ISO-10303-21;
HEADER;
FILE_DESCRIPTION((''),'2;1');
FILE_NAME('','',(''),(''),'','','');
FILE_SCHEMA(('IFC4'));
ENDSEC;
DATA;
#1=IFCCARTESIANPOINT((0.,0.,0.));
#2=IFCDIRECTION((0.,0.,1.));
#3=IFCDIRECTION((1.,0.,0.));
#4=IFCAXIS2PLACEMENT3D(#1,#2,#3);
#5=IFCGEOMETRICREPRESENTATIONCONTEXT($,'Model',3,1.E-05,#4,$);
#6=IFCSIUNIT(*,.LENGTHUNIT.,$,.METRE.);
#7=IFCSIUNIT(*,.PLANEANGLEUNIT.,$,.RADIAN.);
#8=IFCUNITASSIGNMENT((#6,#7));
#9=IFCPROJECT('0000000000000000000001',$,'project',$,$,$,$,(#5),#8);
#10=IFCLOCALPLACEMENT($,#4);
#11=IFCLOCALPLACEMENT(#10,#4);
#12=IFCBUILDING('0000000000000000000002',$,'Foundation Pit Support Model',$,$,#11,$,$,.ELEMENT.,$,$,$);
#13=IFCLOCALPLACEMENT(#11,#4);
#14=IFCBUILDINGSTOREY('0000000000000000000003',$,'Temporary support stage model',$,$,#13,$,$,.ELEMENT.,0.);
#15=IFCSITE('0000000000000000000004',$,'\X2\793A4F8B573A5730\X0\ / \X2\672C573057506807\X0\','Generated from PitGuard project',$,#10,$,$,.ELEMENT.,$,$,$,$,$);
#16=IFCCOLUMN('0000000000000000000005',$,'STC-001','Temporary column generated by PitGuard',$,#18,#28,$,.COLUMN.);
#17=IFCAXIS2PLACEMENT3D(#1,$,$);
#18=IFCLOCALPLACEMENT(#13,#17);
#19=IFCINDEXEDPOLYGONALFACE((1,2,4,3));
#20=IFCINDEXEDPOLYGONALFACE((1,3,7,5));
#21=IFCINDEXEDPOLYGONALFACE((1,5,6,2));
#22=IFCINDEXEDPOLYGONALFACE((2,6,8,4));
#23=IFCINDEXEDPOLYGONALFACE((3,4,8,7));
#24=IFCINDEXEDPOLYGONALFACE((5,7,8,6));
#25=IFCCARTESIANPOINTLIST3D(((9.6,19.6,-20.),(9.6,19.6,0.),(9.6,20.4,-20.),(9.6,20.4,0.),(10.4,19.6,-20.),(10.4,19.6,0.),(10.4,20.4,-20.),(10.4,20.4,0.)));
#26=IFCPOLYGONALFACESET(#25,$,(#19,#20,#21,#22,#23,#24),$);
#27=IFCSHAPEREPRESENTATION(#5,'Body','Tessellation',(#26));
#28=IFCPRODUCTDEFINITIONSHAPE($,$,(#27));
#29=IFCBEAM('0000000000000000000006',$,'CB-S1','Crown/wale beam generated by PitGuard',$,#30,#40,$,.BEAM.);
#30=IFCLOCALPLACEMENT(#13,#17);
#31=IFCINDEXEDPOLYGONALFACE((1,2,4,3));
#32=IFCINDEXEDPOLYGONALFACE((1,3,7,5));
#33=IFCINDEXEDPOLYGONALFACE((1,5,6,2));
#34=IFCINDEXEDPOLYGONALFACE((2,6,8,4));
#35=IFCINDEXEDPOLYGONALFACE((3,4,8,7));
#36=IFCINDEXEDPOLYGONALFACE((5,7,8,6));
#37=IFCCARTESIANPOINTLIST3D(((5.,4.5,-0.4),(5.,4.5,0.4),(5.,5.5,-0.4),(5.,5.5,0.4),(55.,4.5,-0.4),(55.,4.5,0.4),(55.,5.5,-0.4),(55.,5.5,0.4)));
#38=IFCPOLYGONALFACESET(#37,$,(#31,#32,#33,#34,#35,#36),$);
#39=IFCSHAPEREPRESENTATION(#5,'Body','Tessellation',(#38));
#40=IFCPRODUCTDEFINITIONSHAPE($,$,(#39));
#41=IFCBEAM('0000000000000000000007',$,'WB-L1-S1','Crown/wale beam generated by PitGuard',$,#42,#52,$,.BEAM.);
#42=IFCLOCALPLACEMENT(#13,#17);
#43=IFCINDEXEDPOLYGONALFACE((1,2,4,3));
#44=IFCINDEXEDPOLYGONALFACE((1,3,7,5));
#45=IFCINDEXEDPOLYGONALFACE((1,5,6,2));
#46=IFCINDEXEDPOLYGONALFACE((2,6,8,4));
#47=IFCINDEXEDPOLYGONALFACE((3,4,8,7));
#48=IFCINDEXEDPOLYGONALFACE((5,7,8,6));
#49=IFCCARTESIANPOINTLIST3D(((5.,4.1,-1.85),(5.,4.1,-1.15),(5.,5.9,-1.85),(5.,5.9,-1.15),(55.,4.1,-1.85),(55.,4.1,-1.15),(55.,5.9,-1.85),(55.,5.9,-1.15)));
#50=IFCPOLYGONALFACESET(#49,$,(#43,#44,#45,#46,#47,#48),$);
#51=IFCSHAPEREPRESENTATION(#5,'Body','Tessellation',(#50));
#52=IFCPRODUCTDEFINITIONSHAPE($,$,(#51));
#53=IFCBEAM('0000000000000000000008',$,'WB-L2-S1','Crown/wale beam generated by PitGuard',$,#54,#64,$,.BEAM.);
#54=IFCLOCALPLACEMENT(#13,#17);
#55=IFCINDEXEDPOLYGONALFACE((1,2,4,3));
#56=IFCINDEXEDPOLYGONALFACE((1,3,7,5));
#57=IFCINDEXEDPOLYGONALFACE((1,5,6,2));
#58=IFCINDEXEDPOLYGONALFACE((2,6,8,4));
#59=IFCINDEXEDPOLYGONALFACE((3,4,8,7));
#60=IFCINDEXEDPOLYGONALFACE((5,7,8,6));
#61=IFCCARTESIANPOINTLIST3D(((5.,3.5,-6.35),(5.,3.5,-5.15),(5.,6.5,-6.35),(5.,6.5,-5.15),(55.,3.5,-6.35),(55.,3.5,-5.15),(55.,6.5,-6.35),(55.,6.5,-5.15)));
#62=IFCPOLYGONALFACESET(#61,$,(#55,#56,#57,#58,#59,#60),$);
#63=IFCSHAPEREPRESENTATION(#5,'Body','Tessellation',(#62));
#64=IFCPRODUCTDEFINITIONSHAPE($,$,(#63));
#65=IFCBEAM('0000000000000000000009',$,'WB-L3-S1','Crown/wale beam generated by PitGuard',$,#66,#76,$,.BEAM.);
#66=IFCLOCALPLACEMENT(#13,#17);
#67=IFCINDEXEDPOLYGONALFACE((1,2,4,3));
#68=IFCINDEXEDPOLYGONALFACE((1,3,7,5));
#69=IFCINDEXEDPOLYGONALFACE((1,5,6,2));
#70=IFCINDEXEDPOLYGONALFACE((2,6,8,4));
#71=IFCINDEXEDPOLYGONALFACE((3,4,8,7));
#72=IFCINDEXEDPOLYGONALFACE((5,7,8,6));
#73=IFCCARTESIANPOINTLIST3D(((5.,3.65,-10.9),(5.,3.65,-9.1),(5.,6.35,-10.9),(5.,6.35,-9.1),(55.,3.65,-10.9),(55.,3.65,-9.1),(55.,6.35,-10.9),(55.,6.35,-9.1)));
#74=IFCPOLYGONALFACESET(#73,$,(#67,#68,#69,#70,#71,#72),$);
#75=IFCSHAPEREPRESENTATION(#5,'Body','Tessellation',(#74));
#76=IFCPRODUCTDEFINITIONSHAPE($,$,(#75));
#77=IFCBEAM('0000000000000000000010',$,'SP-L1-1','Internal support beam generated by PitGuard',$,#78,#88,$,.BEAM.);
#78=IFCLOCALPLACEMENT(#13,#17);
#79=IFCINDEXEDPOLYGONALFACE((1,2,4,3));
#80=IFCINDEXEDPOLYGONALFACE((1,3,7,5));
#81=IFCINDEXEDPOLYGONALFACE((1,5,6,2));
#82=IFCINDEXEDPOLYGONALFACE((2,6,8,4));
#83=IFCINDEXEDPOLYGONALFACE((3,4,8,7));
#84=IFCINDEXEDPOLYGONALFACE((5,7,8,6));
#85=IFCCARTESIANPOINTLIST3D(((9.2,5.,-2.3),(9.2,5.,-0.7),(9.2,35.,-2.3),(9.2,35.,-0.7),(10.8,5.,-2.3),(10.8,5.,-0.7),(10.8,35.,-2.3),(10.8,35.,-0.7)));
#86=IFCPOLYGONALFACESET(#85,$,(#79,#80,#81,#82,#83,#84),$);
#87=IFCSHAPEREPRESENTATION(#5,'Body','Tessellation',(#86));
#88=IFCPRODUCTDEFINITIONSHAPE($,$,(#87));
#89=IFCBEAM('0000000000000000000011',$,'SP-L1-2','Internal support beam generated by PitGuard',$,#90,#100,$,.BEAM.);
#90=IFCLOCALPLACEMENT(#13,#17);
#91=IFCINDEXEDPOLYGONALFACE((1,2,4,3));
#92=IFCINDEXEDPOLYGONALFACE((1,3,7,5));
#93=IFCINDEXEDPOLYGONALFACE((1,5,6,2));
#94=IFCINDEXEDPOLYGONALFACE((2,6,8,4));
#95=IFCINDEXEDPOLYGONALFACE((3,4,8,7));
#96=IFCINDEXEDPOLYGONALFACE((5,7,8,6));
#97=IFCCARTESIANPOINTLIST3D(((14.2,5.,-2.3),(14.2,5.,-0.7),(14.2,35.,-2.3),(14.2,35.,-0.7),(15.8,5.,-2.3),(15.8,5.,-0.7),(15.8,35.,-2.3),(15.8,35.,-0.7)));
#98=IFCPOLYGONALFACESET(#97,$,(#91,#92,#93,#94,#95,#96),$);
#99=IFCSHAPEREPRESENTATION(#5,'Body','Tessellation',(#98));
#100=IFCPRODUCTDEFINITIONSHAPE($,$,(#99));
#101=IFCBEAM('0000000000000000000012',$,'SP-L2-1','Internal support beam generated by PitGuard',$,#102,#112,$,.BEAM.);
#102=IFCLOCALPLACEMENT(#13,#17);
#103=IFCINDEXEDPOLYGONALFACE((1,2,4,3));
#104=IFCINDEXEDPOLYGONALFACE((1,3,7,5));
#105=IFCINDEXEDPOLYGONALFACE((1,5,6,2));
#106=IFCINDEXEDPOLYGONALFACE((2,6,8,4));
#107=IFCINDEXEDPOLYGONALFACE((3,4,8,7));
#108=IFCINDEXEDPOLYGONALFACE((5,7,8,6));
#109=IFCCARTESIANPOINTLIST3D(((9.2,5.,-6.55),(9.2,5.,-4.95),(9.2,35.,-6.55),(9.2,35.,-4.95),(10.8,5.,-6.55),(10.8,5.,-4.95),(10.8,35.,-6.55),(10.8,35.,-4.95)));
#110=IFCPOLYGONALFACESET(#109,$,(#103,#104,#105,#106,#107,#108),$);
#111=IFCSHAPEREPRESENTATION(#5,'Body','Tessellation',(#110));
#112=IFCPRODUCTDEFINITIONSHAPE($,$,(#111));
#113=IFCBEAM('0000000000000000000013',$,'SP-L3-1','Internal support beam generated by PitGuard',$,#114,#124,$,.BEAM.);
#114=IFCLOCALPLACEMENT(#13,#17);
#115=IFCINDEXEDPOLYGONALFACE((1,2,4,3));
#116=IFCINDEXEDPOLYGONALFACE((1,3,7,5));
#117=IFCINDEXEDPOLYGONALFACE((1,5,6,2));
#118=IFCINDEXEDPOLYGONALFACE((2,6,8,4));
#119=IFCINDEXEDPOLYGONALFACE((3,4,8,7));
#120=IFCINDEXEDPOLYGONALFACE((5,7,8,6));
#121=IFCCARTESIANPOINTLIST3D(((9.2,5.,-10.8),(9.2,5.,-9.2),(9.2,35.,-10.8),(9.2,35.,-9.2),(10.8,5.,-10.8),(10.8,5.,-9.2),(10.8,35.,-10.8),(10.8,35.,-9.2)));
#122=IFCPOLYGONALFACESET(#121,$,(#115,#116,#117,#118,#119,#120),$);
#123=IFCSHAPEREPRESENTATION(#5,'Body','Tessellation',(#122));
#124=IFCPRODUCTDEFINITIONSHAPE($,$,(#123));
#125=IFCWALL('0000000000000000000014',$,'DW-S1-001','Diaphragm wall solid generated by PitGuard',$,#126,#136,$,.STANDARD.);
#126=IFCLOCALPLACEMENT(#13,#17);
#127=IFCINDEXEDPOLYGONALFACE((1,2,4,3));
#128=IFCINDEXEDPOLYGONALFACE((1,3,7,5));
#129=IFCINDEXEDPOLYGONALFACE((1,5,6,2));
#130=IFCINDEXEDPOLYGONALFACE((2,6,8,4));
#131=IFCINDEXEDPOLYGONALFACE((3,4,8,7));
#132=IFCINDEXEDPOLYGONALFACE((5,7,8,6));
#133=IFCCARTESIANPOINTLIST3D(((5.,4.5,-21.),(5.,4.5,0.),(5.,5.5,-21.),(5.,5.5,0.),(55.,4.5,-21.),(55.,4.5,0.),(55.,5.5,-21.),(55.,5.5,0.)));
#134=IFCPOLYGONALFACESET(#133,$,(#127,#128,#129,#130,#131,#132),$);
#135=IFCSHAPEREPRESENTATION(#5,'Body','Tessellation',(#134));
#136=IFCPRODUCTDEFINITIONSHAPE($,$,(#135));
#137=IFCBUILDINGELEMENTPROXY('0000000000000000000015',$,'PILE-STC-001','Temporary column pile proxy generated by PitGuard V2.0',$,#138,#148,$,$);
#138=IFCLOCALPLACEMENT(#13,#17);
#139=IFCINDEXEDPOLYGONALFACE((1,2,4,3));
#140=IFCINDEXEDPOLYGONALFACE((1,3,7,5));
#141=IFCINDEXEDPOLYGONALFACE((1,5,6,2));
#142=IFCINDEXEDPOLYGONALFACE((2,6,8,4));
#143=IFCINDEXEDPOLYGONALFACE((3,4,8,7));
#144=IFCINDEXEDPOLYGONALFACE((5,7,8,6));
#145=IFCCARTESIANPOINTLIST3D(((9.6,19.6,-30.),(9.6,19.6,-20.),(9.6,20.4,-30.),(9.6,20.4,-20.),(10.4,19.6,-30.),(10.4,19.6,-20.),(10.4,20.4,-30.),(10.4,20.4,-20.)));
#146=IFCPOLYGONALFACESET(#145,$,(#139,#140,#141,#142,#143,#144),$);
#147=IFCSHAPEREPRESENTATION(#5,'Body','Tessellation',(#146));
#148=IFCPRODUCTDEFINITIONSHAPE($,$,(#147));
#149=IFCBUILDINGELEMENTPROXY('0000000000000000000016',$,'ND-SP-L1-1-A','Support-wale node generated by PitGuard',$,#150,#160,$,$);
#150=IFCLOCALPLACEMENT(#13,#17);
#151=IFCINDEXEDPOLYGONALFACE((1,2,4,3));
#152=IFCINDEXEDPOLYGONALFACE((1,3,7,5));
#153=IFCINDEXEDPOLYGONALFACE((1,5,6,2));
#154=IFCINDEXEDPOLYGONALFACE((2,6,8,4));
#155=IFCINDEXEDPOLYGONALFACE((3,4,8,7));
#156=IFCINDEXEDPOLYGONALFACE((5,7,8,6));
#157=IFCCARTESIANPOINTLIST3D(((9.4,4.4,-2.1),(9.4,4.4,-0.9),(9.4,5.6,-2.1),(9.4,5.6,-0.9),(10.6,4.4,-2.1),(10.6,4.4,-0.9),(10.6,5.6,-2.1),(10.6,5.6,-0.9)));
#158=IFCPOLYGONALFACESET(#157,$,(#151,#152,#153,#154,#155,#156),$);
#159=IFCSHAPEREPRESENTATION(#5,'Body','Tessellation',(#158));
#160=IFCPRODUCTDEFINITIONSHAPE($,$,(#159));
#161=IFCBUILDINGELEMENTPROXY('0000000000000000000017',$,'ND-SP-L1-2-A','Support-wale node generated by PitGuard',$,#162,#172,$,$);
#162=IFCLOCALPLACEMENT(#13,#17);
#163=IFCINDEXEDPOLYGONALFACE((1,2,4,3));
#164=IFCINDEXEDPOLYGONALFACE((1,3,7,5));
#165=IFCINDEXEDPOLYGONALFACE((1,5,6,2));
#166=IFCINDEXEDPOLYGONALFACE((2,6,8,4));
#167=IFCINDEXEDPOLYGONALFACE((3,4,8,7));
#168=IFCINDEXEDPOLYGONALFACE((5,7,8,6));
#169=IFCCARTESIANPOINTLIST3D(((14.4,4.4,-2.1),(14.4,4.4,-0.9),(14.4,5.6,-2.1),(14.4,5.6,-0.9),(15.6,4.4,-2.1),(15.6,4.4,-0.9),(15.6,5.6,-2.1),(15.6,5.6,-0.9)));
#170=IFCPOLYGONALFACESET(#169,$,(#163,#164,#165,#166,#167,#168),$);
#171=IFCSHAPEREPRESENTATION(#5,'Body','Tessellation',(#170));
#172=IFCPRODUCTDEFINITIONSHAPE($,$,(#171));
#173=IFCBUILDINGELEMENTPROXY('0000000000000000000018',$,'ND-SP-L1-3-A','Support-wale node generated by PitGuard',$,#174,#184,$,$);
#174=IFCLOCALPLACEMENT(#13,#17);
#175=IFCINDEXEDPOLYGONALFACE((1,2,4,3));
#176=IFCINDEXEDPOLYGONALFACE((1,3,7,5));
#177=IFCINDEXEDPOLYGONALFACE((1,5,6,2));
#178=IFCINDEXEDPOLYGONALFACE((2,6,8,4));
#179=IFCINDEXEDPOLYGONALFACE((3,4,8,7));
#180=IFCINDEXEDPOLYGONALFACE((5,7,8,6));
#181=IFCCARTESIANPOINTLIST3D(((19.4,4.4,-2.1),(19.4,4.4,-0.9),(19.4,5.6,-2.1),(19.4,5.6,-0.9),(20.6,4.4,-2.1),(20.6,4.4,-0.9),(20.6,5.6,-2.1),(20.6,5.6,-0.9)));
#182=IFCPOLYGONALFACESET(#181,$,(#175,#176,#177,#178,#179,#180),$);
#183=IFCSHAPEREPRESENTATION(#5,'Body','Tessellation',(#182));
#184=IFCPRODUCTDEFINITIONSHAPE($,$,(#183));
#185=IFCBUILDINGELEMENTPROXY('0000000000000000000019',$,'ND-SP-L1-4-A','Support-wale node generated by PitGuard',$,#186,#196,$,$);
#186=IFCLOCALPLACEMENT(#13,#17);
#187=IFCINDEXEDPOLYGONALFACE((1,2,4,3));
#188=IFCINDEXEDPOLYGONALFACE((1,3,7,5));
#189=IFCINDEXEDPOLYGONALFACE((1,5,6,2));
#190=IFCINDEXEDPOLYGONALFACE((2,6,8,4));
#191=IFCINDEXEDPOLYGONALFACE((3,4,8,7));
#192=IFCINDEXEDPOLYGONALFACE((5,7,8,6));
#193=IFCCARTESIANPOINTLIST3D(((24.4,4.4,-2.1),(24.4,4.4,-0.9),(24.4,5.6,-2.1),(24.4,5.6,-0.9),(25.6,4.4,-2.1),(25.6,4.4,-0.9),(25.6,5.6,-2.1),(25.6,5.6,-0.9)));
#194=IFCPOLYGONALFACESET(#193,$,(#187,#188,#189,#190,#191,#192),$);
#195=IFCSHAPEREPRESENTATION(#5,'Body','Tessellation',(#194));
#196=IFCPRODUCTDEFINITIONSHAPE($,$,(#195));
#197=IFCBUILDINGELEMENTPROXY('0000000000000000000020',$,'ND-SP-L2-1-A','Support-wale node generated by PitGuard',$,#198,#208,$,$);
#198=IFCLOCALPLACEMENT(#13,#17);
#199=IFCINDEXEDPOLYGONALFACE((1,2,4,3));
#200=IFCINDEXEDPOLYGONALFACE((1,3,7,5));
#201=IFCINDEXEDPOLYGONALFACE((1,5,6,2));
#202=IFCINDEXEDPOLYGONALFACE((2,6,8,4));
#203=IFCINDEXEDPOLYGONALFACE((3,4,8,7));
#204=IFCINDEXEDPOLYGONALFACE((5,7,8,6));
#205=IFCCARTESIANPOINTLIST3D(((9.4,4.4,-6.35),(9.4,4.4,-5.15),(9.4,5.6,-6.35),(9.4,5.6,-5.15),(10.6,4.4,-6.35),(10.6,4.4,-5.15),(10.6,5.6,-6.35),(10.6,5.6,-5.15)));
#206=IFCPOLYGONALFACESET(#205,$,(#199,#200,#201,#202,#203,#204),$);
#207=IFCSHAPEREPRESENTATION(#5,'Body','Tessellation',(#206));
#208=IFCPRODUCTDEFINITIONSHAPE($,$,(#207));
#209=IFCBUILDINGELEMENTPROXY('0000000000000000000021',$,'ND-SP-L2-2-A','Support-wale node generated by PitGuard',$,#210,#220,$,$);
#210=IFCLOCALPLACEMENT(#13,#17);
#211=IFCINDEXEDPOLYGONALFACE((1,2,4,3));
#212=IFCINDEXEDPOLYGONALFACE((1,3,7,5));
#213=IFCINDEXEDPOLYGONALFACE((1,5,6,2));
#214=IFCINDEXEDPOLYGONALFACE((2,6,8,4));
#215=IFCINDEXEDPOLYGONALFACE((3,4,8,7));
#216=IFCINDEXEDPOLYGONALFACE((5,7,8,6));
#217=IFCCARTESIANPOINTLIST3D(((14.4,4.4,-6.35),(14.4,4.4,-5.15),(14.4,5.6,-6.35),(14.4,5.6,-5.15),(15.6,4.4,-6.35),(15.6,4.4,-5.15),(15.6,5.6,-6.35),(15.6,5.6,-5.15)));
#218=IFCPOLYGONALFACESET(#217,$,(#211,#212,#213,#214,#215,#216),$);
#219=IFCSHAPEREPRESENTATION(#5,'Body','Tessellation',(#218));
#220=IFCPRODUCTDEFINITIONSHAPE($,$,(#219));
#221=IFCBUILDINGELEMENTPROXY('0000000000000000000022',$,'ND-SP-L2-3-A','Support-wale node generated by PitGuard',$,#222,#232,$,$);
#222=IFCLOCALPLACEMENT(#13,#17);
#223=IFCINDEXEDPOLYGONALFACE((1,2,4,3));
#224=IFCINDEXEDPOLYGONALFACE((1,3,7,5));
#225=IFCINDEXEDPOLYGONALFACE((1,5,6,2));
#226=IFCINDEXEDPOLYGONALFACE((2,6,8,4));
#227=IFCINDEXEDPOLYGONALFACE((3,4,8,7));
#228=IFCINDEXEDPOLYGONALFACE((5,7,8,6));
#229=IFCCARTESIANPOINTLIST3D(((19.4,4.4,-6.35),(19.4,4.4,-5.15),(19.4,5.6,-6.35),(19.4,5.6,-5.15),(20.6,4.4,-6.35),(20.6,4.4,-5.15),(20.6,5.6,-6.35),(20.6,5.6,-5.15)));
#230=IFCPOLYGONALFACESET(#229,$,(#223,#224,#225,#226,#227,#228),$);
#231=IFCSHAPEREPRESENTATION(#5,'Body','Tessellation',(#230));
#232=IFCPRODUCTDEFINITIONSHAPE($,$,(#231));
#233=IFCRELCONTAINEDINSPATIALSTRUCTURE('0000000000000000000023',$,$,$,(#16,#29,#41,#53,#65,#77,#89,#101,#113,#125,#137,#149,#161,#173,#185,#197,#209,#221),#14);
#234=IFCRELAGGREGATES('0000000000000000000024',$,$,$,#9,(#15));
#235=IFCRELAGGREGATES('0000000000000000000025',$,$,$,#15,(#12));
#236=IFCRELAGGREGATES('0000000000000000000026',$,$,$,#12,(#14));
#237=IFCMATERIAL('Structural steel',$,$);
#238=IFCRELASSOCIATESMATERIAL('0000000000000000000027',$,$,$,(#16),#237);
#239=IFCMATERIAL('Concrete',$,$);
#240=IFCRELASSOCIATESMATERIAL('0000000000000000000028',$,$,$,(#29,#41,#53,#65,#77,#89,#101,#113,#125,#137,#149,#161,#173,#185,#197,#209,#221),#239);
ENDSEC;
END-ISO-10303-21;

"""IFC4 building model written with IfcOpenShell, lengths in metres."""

from ifc_helpers import new_model, si_unit, frame, origin_with_axes, origin_2d, place, context, project, spatial, rectangle, extrude, material, element, save


model = new_model("IFC4")

# Units and contexts
model_context = context("Model", 3, precision=1e-05, world=origin_with_axes())
ifc_project = project(units=[si_unit("LENGTHUNIT", "METRE"), si_unit("PLANEANGLEUNIT", "RADIAN")], contexts=[model_context])

# Site, building, storey
site_placement = place(None, origin_with_axes())
site = spatial("IfcSite", under=ifc_project, at=site_placement, Name="示例场地 / 本地坐标", Description="Generated from PitGuard project", CompositionType="ELEMENT")
building_placement = place(site_placement, origin_with_axes())
building = spatial("IfcBuilding", under=site, at=building_placement, Name="Foundation Pit Support Model", CompositionType="ELEMENT")
storey_placement = place(building_placement, origin_with_axes())
storey = spatial("IfcBuildingStorey", under=building, at=storey_placement, Name="Temporary support stage model", CompositionType="ELEMENT", Elevation=0.0)

# Column
ifc_material_1 = material(Name="Structural steel")
column_placement = place(storey_placement, frame((10.0, 20.0, -20.0), z_axis=(0.0, 0.0, 1.0), x_axis=(1.0, 0.0, 0.0)))
element("IfcColumn", 1, at=column_placement, inside=storey, material=ifc_material_1, Name="STC-001", Description="Temporary column generated by PitGuard", PredefinedType="COLUMN", context=model_context, shape_type="SweptSolid", body=[
    extrude(rectangle(XDim=0.8, YDim=0.8, at=origin_2d()), origin_with_axes(), (0.0, 0.0, 1.0), 20.0),
])

# Beams
ifc_material_2 = material(Name="Concrete")
beam_1_placement = place(storey_placement, frame((30.0, 5.0, -0.4), z_axis=(0.0, 0.0, 1.0), x_axis=(1.0, 0.0, 0.0)))
element("IfcBeam", 2, at=beam_1_placement, inside=storey, material=ifc_material_2, Name="CB-S1", Description="Crown/wale beam generated by PitGuard", PredefinedType="BEAM", context=model_context, shape_type="SweptSolid", body=[
    extrude(rectangle(XDim=50.0, YDim=1.0, at=origin_2d()), origin_with_axes(), (0.0, 0.0, 1.0), 0.8),
])
beam_2_placement = place(storey_placement, frame((30.0, 5.0, -1.85), z_axis=(0.0, 0.0, 1.0), x_axis=(1.0, 0.0, 0.0)))
element("IfcBeam", 3, at=beam_2_placement, inside=storey, material=ifc_material_2, Name="WB-L1-S1", Description="Crown/wale beam generated by PitGuard", PredefinedType="BEAM", context=model_context, shape_type="SweptSolid", body=[
    extrude(rectangle(XDim=50.0, YDim=1.8, at=origin_2d()), origin_with_axes(), (0.0, 0.0, 1.0), 0.7),
])
beam_3_placement = place(storey_placement, frame((30.0, 5.0, -6.35), z_axis=(0.0, 0.0, 1.0), x_axis=(1.0, 0.0, 0.0)))
element("IfcBeam", 4, at=beam_3_placement, inside=storey, material=ifc_material_2, Name="WB-L2-S1", Description="Crown/wale beam generated by PitGuard", PredefinedType="BEAM", context=model_context, shape_type="SweptSolid", body=[
    extrude(rectangle(XDim=50.0, YDim=3.0, at=origin_2d()), origin_with_axes(), (0.0, 0.0, 1.0), 1.2),
])
beam_4_placement = place(storey_placement, frame((30.0, 5.0, -10.9), z_axis=(0.0, 0.0, 1.0), x_axis=(1.0, 0.0, 0.0)))
element("IfcBeam", 5, at=beam_4_placement, inside=storey, material=ifc_material_2, Name="WB-L3-S1", Description="Crown/wale beam generated by PitGuard", PredefinedType="BEAM", context=model_context, shape_type="SweptSolid", body=[
    extrude(rectangle(XDim=50.0, YDim=2.7, at=origin_2d()), origin_with_axes(), (0.0, 0.0, 1.0), 1.8),
])
for number, where, z_axis, x_axis, name in (
    (6, (10.0, 20.0, -2.3), (0.0, 0.0, 1.0), (0.0, 1.0, 0.0), "SP-L1-1"),
    (7, (15.0, 20.0, -2.3), (0.0, 0.0, 1.0), (0.0, 1.0, 0.0), "SP-L1-2"),
    (8, (10.0, 20.0, -6.55), (0.0, 0.0, 1.0), (0.0, 1.0, 0.0), "SP-L2-1"),
    (9, (10.0, 20.0, -10.8), (0.0, 0.0, 1.0), (0.0, 1.0, 0.0), "SP-L3-1"),
):
    element("IfcBeam", number, at=place(storey_placement, frame(where, z_axis=z_axis, x_axis=x_axis)), inside=storey, material=ifc_material_2, Name=name, Description="Internal support beam generated by PitGuard", PredefinedType="BEAM", context=model_context, shape_type="SweptSolid", body=[
        extrude(rectangle(XDim=30.0, YDim=1.6, at=origin_2d()), origin_with_axes(), (0.0, 0.0, 1.0), 1.6),
    ])

# Wall
wall_placement = place(storey_placement, frame((30.0, 5.0, -21.0), z_axis=(0.0, 0.0, 1.0), x_axis=(1.0, 0.0, 0.0)))
element("IfcWall", 10, at=wall_placement, inside=storey, material=ifc_material_2, Name="DW-S1-001", Description="Diaphragm wall solid generated by PitGuard", PredefinedType="STANDARD", context=model_context, shape_type="SweptSolid", body=[
    extrude(rectangle(XDim=50.0, YDim=1.0, at=origin_2d()), origin_with_axes(), (0.0, 0.0, 1.0), 21.0),
])

# Building element proxies
proxy_placement = place(storey_placement, frame((10.0, 20.0, -30.0), z_axis=(0.0, 0.0, 1.0), x_axis=(1.0, 0.0, 0.0)))
element("IfcBuildingElementProxy", 11, at=proxy_placement, inside=storey, material=ifc_material_2, Name="PILE-STC-001", Description="Temporary column pile proxy generated by PitGuard V2.0", context=model_context, shape_type="SweptSolid", body=[
    extrude(rectangle(XDim=0.8, YDim=0.8, at=origin_2d()), origin_with_axes(), (0.0, 0.0, 1.0), 10.0),
])
for number, where, z_axis, x_axis, name in (
    (12, (10.0, 5.0, -2.1), (0.0, 0.0, 1.0), (1.0, 0.0, 0.0), "ND-SP-L1-1-A"),
    (13, (15.0, 5.0, -2.1), (0.0, 0.0, 1.0), (1.0, 0.0, 0.0), "ND-SP-L1-2-A"),
    (14, (20.0, 5.0, -2.1), (0.0, 0.0, 1.0), (1.0, 0.0, 0.0), "ND-SP-L1-3-A"),
    (15, (25.0, 5.0, -2.1), (0.0, 0.0, 1.0), (1.0, 0.0, 0.0), "ND-SP-L1-4-A"),
    (16, (10.0, 5.0, -6.35), (0.0, 0.0, 1.0), (1.0, 0.0, 0.0), "ND-SP-L2-1-A"),
    (17, (15.0, 5.0, -6.35), (0.0, 0.0, 1.0), (1.0, 0.0, 0.0), "ND-SP-L2-2-A"),
    (18, (20.0, 5.0, -6.35), (0.0, 0.0, 1.0), (1.0, 0.0, 0.0), "ND-SP-L2-3-A"),
):
    element("IfcBuildingElementProxy", number, at=place(storey_placement, frame(where, z_axis=z_axis, x_axis=x_axis)), inside=storey, material=ifc_material_2, Name=name, Description="Support-wale node generated by PitGuard", context=model_context, shape_type="SweptSolid", body=[
        extrude(rectangle(XDim=1.2, YDim=1.2, at=origin_2d()), origin_with_axes(), (0.0, 0.0, 1.0), 1.2),
    ])

save(model, "model.ifc")
